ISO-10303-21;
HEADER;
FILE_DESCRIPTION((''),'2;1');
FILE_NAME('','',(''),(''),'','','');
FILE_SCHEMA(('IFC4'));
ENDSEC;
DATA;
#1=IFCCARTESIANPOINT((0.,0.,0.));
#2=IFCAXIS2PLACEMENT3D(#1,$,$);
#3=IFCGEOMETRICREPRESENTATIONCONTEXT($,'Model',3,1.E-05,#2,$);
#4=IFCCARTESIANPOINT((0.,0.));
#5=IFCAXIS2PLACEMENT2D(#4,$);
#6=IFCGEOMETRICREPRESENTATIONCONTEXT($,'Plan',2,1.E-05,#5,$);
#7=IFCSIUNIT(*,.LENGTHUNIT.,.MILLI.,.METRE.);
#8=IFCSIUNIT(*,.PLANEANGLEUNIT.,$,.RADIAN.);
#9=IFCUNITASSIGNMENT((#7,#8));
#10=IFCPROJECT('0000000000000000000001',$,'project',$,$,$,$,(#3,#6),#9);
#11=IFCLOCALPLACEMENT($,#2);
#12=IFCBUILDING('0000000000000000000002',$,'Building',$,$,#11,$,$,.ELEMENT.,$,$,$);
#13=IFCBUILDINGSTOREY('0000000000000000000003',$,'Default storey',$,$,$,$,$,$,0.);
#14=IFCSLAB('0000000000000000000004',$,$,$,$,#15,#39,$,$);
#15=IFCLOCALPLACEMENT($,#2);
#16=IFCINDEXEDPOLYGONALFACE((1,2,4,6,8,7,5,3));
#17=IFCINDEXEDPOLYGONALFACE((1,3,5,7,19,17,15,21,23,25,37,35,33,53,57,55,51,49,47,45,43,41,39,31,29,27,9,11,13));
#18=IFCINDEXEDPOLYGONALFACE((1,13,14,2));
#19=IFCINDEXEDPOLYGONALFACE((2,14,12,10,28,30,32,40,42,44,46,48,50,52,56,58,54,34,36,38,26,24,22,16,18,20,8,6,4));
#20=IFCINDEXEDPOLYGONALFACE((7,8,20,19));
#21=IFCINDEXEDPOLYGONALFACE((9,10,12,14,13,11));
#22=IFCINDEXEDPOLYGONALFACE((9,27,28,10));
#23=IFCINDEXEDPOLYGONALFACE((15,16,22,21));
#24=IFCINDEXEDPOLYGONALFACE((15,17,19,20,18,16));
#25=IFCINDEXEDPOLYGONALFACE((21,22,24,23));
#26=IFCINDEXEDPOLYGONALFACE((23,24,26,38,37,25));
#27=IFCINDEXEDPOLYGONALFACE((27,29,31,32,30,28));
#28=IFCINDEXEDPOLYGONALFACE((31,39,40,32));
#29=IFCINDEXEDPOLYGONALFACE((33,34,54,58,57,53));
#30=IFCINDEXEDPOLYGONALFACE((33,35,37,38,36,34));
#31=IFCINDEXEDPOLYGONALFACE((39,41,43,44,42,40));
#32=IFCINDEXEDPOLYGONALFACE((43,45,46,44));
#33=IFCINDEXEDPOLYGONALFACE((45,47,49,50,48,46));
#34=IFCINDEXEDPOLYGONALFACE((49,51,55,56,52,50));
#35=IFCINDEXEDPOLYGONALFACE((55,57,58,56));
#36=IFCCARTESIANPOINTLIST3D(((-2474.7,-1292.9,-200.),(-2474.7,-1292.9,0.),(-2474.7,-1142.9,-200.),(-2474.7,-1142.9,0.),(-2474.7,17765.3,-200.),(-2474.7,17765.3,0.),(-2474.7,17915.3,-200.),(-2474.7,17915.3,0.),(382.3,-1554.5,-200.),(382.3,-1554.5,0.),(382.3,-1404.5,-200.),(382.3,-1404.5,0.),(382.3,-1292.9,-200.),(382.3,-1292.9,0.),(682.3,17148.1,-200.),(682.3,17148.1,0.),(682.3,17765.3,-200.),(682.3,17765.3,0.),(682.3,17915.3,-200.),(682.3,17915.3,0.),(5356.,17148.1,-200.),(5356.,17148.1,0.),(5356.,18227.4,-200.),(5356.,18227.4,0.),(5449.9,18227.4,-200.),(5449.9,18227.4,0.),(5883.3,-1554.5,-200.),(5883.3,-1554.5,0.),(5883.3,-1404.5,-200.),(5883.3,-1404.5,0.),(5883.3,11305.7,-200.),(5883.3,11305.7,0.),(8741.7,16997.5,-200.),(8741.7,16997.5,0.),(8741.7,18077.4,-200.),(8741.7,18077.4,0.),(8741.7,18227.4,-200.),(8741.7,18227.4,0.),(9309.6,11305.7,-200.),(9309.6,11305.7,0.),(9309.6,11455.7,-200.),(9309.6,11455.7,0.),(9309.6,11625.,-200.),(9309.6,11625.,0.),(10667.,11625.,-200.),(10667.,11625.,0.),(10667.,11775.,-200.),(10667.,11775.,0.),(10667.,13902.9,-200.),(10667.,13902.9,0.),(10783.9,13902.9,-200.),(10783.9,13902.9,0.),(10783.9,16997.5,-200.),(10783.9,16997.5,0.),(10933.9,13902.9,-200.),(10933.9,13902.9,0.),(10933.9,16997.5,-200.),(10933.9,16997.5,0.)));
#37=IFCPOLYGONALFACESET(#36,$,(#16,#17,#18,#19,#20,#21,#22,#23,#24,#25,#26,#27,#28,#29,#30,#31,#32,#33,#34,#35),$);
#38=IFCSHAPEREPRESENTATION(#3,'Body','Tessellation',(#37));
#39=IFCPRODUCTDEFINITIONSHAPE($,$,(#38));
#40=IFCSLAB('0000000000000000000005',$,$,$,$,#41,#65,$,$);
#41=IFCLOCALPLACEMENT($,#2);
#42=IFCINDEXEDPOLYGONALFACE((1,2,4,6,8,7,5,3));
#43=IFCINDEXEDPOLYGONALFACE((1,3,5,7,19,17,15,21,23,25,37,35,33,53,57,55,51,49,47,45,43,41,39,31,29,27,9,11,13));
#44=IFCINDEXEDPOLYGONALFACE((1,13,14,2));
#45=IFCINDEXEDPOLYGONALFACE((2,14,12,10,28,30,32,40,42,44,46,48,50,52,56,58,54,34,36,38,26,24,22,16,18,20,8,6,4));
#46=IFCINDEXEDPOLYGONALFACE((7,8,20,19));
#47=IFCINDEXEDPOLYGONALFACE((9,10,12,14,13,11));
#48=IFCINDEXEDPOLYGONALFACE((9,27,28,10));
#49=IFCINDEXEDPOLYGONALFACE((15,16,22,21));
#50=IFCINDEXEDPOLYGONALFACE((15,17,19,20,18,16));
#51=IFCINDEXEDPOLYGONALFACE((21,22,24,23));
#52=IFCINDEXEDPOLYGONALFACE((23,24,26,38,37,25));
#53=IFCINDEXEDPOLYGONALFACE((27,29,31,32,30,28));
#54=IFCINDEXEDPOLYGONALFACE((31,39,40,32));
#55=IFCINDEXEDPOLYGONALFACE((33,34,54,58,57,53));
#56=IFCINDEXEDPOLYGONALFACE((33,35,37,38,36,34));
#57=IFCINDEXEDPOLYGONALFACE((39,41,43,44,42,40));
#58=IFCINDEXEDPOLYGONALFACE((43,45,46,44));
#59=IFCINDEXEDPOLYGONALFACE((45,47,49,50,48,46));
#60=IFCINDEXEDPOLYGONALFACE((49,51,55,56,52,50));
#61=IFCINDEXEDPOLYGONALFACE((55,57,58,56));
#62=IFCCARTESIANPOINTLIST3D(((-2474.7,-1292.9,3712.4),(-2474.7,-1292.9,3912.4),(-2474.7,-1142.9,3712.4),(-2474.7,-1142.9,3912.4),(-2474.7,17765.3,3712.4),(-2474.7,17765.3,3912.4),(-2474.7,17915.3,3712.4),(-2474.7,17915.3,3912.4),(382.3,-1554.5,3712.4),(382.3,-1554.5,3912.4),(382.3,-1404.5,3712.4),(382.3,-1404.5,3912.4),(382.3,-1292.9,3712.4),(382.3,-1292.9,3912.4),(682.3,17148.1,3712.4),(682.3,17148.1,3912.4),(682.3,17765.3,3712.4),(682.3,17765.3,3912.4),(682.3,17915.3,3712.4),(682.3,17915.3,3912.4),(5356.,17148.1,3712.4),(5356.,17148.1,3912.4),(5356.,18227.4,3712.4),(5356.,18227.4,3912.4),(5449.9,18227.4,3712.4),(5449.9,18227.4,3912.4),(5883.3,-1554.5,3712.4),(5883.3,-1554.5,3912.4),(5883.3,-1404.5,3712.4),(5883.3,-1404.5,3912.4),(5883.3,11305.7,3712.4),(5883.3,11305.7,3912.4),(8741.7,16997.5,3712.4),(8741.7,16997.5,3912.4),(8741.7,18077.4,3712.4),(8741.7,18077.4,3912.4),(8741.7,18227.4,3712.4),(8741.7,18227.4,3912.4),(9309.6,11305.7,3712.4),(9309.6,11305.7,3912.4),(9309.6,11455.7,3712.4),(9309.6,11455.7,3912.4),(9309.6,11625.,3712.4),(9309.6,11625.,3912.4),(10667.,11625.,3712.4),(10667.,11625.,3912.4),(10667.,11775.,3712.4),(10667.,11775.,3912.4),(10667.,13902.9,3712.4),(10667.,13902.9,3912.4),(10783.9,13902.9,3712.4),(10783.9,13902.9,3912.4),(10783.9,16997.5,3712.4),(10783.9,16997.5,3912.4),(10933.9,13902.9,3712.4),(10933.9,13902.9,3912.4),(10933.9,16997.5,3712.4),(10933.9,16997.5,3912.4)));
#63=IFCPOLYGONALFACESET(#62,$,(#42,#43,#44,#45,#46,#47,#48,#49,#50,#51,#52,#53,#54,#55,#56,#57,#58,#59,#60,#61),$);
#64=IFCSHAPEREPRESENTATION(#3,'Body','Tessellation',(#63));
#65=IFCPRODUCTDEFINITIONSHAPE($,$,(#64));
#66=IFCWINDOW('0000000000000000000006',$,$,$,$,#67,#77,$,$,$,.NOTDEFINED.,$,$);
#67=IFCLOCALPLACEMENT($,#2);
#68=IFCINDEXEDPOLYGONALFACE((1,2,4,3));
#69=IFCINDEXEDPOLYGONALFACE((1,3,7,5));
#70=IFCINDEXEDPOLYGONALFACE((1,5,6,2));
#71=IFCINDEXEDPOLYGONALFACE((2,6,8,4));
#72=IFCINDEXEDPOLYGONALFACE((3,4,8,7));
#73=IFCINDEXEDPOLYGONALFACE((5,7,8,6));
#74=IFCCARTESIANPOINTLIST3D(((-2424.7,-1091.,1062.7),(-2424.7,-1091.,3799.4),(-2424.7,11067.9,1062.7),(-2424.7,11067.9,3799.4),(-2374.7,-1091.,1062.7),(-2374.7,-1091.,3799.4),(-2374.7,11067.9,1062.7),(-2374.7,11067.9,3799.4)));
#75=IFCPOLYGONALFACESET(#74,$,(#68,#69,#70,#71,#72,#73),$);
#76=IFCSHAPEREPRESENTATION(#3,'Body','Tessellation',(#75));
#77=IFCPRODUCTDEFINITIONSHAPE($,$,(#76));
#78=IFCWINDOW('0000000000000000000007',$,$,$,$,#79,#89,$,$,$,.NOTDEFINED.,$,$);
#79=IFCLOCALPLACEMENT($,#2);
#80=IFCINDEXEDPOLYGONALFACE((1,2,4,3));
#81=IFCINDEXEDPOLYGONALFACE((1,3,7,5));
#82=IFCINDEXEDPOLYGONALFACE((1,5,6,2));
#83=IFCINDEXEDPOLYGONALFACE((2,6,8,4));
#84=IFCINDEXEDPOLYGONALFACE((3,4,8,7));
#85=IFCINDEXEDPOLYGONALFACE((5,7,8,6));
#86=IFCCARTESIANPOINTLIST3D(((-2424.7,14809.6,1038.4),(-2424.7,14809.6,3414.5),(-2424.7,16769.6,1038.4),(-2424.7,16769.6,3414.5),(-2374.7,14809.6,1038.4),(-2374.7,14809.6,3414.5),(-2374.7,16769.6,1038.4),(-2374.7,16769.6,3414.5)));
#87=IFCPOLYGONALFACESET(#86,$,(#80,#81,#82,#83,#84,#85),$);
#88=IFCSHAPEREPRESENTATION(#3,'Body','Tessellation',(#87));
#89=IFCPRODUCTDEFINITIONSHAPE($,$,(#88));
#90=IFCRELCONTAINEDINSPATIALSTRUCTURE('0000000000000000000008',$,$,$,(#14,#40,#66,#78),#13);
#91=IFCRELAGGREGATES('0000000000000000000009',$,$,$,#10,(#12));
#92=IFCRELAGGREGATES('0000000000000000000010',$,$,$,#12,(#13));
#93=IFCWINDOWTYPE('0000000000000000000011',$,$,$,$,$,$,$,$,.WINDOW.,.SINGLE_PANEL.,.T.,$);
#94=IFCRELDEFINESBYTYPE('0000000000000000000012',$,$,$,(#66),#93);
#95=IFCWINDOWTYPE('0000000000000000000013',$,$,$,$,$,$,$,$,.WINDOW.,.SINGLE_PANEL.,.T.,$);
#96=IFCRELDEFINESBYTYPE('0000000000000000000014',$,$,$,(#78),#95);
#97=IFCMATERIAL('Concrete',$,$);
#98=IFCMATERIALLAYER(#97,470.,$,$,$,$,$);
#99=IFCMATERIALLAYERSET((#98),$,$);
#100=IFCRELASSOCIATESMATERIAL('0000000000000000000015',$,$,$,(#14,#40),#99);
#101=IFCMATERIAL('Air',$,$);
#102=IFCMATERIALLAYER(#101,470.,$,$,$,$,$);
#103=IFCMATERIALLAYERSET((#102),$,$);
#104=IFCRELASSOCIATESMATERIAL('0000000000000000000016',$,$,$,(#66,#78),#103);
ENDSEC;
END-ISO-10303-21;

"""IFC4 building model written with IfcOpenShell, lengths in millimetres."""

from ifc_helpers import new_model, si_unit, frame, origin, origin_2d, place, context, project, spatial, polyline, rectangle, outline, extrude, material, layer, layer_set, layer_usage, type_object, element, save


model = new_model("IFC4")

# Units and contexts
model_context = context("Model", 3, precision=1e-05, world=origin())
plan_context = context("Plan", 2, precision=1e-05, world=origin_2d())
ifc_project = project(units=[si_unit("LENGTHUNIT", "METRE", prefix="MILLI"), si_unit("PLANEANGLEUNIT", "RADIAN")], contexts=[model_context, plan_context])

# Building, storey
placement = place(None, origin())
building = spatial("IfcBuilding", under=ifc_project, at=placement, Name="Building", CompositionType="ELEMENT")
storey = spatial("IfcBuildingStorey", under=building, Name="Default storey", Elevation=0.0)

# Slabs
ifc_material_1 = material(Name="Concrete")
ifc_layer_1 = layer(ifc_material_1, 470.0)
ifc_layer_set_1 = layer_set([ifc_layer_1])
ifc_layer_usage_1 = layer_usage(ifc_layer_set_1, "AXIS3", "POSITIVE", 0.0)
element("IfcSlab", 1, at=placement, inside=storey, material=ifc_layer_usage_1, context=model_context, shape_type="SweptSolid", body=[
    extrude(outline(polyline([(8741.7, 16997.5), (8741.7, 18077.4), (8741.7, 18227.4), (5449.9, 18227.4), (5356.0, 18227.4), (5356.0, 17148.1), (682.3, 17148.1), (682.3, 17765.3), (682.3, 17915.3), (-2474.7, 17915.3), (-2474.7, 17765.3), (-2474.7, -1142.9), (-2474.7, -1292.9), (382.3, -1292.9), (382.3, -1404.5), (382.3, -1554.5), (5883.3, -1554.5), (5883.3, -1404.5), (5883.3, 11305.7), (9309.6, 11305.7), (9309.6, 11455.7), (9309.6, 11625.0), (10667.0, 11625.0), (10667.0, 11775.0), (10667.0, 13902.9), (10783.9, 13902.9), (10933.9, 13902.9), (10933.9, 16997.5), (10783.9, 16997.5), (8741.7, 16997.5)])), frame((0.0, 0.0, -200.0), z_axis=(0.0, 0.0, 1000.0), x_axis=(1000.0, 0.0, 0.0)), (0.0, 0.0, 1.0), 200.0),
])
element("IfcSlab", 2, at=placement, inside=storey, material=ifc_layer_usage_1, context=model_context, shape_type="SweptSolid", body=[
    extrude(outline(polyline([(8741.7, 16997.5), (8741.7, 18077.4), (8741.7, 18227.4), (5449.9, 18227.4), (5356.0, 18227.4), (5356.0, 17148.1), (682.3, 17148.1), (682.3, 17765.3), (682.3, 17915.3), (-2474.7, 17915.3), (-2474.7, 17765.3), (-2474.7, -1142.9), (-2474.7, -1292.9), (382.3, -1292.9), (382.3, -1404.5), (382.3, -1554.5), (5883.3, -1554.5), (5883.3, -1404.5), (5883.3, 11305.7), (9309.6, 11305.7), (9309.6, 11455.7), (9309.6, 11625.0), (10667.0, 11625.0), (10667.0, 11775.0), (10667.0, 13902.9), (10783.9, 13902.9), (10933.9, 13902.9), (10933.9, 16997.5), (10783.9, 16997.5), (8741.7, 16997.5)])), frame((0.0, 0.0, 3912.4), z_axis=(0.0, 0.0, 1000.0), x_axis=(1000.0, 0.0, 0.0)), (0.0, 0.0, -1.0), 200.0),
])

# Windows
ifc_material_2 = material(Name="Air")
ifc_layer_2 = layer(ifc_material_2, 470.0)
ifc_layer_set_2 = layer_set([ifc_layer_2])
ifc_layer_usage_2 = layer_usage(ifc_layer_set_2, "AXIS3", "POSITIVE", 0.0)
window_type_1 = type_object("IfcWindowType", ParameterTakesPrecedence=True, PartitioningType="SINGLE_PANEL", PredefinedType="WINDOW")
element("IfcWindow", 3, at=placement, inside=storey, type_object=window_type_1, material=ifc_layer_usage_2, PredefinedType="NOTDEFINED", context=model_context, shape_type="CSG", body=[
    extrude(rectangle(XDim=12158.9, YDim=50.0, at=origin_2d()), frame((-2399.7, 4988.4, 1062.7), z_axis=(0.0, 0.0, 1000.0), x_axis=(0.0, 12158.909678, 0.0)), (0.0, 0.0, 1.0), 2736.7),
])
window_type_2 = type_object("IfcWindowType", ParameterTakesPrecedence=True, PartitioningType="SINGLE_PANEL", PredefinedType="WINDOW")
element("IfcWindow", 4, at=placement, inside=storey, type_object=window_type_2, material=ifc_layer_usage_2, PredefinedType="NOTDEFINED", context=model_context, shape_type="CSG", body=[
    extrude(rectangle(XDim=1960.0, YDim=50.0, at=origin_2d()), frame((-2399.7, 15789.6, 1038.4), z_axis=(0.0, 0.0, 1000.0), x_axis=(0.0, 1960.000038, 0.0)), (0.0, 0.0, 1.0), 2376.1),
])

save(model, "model.ifc")
